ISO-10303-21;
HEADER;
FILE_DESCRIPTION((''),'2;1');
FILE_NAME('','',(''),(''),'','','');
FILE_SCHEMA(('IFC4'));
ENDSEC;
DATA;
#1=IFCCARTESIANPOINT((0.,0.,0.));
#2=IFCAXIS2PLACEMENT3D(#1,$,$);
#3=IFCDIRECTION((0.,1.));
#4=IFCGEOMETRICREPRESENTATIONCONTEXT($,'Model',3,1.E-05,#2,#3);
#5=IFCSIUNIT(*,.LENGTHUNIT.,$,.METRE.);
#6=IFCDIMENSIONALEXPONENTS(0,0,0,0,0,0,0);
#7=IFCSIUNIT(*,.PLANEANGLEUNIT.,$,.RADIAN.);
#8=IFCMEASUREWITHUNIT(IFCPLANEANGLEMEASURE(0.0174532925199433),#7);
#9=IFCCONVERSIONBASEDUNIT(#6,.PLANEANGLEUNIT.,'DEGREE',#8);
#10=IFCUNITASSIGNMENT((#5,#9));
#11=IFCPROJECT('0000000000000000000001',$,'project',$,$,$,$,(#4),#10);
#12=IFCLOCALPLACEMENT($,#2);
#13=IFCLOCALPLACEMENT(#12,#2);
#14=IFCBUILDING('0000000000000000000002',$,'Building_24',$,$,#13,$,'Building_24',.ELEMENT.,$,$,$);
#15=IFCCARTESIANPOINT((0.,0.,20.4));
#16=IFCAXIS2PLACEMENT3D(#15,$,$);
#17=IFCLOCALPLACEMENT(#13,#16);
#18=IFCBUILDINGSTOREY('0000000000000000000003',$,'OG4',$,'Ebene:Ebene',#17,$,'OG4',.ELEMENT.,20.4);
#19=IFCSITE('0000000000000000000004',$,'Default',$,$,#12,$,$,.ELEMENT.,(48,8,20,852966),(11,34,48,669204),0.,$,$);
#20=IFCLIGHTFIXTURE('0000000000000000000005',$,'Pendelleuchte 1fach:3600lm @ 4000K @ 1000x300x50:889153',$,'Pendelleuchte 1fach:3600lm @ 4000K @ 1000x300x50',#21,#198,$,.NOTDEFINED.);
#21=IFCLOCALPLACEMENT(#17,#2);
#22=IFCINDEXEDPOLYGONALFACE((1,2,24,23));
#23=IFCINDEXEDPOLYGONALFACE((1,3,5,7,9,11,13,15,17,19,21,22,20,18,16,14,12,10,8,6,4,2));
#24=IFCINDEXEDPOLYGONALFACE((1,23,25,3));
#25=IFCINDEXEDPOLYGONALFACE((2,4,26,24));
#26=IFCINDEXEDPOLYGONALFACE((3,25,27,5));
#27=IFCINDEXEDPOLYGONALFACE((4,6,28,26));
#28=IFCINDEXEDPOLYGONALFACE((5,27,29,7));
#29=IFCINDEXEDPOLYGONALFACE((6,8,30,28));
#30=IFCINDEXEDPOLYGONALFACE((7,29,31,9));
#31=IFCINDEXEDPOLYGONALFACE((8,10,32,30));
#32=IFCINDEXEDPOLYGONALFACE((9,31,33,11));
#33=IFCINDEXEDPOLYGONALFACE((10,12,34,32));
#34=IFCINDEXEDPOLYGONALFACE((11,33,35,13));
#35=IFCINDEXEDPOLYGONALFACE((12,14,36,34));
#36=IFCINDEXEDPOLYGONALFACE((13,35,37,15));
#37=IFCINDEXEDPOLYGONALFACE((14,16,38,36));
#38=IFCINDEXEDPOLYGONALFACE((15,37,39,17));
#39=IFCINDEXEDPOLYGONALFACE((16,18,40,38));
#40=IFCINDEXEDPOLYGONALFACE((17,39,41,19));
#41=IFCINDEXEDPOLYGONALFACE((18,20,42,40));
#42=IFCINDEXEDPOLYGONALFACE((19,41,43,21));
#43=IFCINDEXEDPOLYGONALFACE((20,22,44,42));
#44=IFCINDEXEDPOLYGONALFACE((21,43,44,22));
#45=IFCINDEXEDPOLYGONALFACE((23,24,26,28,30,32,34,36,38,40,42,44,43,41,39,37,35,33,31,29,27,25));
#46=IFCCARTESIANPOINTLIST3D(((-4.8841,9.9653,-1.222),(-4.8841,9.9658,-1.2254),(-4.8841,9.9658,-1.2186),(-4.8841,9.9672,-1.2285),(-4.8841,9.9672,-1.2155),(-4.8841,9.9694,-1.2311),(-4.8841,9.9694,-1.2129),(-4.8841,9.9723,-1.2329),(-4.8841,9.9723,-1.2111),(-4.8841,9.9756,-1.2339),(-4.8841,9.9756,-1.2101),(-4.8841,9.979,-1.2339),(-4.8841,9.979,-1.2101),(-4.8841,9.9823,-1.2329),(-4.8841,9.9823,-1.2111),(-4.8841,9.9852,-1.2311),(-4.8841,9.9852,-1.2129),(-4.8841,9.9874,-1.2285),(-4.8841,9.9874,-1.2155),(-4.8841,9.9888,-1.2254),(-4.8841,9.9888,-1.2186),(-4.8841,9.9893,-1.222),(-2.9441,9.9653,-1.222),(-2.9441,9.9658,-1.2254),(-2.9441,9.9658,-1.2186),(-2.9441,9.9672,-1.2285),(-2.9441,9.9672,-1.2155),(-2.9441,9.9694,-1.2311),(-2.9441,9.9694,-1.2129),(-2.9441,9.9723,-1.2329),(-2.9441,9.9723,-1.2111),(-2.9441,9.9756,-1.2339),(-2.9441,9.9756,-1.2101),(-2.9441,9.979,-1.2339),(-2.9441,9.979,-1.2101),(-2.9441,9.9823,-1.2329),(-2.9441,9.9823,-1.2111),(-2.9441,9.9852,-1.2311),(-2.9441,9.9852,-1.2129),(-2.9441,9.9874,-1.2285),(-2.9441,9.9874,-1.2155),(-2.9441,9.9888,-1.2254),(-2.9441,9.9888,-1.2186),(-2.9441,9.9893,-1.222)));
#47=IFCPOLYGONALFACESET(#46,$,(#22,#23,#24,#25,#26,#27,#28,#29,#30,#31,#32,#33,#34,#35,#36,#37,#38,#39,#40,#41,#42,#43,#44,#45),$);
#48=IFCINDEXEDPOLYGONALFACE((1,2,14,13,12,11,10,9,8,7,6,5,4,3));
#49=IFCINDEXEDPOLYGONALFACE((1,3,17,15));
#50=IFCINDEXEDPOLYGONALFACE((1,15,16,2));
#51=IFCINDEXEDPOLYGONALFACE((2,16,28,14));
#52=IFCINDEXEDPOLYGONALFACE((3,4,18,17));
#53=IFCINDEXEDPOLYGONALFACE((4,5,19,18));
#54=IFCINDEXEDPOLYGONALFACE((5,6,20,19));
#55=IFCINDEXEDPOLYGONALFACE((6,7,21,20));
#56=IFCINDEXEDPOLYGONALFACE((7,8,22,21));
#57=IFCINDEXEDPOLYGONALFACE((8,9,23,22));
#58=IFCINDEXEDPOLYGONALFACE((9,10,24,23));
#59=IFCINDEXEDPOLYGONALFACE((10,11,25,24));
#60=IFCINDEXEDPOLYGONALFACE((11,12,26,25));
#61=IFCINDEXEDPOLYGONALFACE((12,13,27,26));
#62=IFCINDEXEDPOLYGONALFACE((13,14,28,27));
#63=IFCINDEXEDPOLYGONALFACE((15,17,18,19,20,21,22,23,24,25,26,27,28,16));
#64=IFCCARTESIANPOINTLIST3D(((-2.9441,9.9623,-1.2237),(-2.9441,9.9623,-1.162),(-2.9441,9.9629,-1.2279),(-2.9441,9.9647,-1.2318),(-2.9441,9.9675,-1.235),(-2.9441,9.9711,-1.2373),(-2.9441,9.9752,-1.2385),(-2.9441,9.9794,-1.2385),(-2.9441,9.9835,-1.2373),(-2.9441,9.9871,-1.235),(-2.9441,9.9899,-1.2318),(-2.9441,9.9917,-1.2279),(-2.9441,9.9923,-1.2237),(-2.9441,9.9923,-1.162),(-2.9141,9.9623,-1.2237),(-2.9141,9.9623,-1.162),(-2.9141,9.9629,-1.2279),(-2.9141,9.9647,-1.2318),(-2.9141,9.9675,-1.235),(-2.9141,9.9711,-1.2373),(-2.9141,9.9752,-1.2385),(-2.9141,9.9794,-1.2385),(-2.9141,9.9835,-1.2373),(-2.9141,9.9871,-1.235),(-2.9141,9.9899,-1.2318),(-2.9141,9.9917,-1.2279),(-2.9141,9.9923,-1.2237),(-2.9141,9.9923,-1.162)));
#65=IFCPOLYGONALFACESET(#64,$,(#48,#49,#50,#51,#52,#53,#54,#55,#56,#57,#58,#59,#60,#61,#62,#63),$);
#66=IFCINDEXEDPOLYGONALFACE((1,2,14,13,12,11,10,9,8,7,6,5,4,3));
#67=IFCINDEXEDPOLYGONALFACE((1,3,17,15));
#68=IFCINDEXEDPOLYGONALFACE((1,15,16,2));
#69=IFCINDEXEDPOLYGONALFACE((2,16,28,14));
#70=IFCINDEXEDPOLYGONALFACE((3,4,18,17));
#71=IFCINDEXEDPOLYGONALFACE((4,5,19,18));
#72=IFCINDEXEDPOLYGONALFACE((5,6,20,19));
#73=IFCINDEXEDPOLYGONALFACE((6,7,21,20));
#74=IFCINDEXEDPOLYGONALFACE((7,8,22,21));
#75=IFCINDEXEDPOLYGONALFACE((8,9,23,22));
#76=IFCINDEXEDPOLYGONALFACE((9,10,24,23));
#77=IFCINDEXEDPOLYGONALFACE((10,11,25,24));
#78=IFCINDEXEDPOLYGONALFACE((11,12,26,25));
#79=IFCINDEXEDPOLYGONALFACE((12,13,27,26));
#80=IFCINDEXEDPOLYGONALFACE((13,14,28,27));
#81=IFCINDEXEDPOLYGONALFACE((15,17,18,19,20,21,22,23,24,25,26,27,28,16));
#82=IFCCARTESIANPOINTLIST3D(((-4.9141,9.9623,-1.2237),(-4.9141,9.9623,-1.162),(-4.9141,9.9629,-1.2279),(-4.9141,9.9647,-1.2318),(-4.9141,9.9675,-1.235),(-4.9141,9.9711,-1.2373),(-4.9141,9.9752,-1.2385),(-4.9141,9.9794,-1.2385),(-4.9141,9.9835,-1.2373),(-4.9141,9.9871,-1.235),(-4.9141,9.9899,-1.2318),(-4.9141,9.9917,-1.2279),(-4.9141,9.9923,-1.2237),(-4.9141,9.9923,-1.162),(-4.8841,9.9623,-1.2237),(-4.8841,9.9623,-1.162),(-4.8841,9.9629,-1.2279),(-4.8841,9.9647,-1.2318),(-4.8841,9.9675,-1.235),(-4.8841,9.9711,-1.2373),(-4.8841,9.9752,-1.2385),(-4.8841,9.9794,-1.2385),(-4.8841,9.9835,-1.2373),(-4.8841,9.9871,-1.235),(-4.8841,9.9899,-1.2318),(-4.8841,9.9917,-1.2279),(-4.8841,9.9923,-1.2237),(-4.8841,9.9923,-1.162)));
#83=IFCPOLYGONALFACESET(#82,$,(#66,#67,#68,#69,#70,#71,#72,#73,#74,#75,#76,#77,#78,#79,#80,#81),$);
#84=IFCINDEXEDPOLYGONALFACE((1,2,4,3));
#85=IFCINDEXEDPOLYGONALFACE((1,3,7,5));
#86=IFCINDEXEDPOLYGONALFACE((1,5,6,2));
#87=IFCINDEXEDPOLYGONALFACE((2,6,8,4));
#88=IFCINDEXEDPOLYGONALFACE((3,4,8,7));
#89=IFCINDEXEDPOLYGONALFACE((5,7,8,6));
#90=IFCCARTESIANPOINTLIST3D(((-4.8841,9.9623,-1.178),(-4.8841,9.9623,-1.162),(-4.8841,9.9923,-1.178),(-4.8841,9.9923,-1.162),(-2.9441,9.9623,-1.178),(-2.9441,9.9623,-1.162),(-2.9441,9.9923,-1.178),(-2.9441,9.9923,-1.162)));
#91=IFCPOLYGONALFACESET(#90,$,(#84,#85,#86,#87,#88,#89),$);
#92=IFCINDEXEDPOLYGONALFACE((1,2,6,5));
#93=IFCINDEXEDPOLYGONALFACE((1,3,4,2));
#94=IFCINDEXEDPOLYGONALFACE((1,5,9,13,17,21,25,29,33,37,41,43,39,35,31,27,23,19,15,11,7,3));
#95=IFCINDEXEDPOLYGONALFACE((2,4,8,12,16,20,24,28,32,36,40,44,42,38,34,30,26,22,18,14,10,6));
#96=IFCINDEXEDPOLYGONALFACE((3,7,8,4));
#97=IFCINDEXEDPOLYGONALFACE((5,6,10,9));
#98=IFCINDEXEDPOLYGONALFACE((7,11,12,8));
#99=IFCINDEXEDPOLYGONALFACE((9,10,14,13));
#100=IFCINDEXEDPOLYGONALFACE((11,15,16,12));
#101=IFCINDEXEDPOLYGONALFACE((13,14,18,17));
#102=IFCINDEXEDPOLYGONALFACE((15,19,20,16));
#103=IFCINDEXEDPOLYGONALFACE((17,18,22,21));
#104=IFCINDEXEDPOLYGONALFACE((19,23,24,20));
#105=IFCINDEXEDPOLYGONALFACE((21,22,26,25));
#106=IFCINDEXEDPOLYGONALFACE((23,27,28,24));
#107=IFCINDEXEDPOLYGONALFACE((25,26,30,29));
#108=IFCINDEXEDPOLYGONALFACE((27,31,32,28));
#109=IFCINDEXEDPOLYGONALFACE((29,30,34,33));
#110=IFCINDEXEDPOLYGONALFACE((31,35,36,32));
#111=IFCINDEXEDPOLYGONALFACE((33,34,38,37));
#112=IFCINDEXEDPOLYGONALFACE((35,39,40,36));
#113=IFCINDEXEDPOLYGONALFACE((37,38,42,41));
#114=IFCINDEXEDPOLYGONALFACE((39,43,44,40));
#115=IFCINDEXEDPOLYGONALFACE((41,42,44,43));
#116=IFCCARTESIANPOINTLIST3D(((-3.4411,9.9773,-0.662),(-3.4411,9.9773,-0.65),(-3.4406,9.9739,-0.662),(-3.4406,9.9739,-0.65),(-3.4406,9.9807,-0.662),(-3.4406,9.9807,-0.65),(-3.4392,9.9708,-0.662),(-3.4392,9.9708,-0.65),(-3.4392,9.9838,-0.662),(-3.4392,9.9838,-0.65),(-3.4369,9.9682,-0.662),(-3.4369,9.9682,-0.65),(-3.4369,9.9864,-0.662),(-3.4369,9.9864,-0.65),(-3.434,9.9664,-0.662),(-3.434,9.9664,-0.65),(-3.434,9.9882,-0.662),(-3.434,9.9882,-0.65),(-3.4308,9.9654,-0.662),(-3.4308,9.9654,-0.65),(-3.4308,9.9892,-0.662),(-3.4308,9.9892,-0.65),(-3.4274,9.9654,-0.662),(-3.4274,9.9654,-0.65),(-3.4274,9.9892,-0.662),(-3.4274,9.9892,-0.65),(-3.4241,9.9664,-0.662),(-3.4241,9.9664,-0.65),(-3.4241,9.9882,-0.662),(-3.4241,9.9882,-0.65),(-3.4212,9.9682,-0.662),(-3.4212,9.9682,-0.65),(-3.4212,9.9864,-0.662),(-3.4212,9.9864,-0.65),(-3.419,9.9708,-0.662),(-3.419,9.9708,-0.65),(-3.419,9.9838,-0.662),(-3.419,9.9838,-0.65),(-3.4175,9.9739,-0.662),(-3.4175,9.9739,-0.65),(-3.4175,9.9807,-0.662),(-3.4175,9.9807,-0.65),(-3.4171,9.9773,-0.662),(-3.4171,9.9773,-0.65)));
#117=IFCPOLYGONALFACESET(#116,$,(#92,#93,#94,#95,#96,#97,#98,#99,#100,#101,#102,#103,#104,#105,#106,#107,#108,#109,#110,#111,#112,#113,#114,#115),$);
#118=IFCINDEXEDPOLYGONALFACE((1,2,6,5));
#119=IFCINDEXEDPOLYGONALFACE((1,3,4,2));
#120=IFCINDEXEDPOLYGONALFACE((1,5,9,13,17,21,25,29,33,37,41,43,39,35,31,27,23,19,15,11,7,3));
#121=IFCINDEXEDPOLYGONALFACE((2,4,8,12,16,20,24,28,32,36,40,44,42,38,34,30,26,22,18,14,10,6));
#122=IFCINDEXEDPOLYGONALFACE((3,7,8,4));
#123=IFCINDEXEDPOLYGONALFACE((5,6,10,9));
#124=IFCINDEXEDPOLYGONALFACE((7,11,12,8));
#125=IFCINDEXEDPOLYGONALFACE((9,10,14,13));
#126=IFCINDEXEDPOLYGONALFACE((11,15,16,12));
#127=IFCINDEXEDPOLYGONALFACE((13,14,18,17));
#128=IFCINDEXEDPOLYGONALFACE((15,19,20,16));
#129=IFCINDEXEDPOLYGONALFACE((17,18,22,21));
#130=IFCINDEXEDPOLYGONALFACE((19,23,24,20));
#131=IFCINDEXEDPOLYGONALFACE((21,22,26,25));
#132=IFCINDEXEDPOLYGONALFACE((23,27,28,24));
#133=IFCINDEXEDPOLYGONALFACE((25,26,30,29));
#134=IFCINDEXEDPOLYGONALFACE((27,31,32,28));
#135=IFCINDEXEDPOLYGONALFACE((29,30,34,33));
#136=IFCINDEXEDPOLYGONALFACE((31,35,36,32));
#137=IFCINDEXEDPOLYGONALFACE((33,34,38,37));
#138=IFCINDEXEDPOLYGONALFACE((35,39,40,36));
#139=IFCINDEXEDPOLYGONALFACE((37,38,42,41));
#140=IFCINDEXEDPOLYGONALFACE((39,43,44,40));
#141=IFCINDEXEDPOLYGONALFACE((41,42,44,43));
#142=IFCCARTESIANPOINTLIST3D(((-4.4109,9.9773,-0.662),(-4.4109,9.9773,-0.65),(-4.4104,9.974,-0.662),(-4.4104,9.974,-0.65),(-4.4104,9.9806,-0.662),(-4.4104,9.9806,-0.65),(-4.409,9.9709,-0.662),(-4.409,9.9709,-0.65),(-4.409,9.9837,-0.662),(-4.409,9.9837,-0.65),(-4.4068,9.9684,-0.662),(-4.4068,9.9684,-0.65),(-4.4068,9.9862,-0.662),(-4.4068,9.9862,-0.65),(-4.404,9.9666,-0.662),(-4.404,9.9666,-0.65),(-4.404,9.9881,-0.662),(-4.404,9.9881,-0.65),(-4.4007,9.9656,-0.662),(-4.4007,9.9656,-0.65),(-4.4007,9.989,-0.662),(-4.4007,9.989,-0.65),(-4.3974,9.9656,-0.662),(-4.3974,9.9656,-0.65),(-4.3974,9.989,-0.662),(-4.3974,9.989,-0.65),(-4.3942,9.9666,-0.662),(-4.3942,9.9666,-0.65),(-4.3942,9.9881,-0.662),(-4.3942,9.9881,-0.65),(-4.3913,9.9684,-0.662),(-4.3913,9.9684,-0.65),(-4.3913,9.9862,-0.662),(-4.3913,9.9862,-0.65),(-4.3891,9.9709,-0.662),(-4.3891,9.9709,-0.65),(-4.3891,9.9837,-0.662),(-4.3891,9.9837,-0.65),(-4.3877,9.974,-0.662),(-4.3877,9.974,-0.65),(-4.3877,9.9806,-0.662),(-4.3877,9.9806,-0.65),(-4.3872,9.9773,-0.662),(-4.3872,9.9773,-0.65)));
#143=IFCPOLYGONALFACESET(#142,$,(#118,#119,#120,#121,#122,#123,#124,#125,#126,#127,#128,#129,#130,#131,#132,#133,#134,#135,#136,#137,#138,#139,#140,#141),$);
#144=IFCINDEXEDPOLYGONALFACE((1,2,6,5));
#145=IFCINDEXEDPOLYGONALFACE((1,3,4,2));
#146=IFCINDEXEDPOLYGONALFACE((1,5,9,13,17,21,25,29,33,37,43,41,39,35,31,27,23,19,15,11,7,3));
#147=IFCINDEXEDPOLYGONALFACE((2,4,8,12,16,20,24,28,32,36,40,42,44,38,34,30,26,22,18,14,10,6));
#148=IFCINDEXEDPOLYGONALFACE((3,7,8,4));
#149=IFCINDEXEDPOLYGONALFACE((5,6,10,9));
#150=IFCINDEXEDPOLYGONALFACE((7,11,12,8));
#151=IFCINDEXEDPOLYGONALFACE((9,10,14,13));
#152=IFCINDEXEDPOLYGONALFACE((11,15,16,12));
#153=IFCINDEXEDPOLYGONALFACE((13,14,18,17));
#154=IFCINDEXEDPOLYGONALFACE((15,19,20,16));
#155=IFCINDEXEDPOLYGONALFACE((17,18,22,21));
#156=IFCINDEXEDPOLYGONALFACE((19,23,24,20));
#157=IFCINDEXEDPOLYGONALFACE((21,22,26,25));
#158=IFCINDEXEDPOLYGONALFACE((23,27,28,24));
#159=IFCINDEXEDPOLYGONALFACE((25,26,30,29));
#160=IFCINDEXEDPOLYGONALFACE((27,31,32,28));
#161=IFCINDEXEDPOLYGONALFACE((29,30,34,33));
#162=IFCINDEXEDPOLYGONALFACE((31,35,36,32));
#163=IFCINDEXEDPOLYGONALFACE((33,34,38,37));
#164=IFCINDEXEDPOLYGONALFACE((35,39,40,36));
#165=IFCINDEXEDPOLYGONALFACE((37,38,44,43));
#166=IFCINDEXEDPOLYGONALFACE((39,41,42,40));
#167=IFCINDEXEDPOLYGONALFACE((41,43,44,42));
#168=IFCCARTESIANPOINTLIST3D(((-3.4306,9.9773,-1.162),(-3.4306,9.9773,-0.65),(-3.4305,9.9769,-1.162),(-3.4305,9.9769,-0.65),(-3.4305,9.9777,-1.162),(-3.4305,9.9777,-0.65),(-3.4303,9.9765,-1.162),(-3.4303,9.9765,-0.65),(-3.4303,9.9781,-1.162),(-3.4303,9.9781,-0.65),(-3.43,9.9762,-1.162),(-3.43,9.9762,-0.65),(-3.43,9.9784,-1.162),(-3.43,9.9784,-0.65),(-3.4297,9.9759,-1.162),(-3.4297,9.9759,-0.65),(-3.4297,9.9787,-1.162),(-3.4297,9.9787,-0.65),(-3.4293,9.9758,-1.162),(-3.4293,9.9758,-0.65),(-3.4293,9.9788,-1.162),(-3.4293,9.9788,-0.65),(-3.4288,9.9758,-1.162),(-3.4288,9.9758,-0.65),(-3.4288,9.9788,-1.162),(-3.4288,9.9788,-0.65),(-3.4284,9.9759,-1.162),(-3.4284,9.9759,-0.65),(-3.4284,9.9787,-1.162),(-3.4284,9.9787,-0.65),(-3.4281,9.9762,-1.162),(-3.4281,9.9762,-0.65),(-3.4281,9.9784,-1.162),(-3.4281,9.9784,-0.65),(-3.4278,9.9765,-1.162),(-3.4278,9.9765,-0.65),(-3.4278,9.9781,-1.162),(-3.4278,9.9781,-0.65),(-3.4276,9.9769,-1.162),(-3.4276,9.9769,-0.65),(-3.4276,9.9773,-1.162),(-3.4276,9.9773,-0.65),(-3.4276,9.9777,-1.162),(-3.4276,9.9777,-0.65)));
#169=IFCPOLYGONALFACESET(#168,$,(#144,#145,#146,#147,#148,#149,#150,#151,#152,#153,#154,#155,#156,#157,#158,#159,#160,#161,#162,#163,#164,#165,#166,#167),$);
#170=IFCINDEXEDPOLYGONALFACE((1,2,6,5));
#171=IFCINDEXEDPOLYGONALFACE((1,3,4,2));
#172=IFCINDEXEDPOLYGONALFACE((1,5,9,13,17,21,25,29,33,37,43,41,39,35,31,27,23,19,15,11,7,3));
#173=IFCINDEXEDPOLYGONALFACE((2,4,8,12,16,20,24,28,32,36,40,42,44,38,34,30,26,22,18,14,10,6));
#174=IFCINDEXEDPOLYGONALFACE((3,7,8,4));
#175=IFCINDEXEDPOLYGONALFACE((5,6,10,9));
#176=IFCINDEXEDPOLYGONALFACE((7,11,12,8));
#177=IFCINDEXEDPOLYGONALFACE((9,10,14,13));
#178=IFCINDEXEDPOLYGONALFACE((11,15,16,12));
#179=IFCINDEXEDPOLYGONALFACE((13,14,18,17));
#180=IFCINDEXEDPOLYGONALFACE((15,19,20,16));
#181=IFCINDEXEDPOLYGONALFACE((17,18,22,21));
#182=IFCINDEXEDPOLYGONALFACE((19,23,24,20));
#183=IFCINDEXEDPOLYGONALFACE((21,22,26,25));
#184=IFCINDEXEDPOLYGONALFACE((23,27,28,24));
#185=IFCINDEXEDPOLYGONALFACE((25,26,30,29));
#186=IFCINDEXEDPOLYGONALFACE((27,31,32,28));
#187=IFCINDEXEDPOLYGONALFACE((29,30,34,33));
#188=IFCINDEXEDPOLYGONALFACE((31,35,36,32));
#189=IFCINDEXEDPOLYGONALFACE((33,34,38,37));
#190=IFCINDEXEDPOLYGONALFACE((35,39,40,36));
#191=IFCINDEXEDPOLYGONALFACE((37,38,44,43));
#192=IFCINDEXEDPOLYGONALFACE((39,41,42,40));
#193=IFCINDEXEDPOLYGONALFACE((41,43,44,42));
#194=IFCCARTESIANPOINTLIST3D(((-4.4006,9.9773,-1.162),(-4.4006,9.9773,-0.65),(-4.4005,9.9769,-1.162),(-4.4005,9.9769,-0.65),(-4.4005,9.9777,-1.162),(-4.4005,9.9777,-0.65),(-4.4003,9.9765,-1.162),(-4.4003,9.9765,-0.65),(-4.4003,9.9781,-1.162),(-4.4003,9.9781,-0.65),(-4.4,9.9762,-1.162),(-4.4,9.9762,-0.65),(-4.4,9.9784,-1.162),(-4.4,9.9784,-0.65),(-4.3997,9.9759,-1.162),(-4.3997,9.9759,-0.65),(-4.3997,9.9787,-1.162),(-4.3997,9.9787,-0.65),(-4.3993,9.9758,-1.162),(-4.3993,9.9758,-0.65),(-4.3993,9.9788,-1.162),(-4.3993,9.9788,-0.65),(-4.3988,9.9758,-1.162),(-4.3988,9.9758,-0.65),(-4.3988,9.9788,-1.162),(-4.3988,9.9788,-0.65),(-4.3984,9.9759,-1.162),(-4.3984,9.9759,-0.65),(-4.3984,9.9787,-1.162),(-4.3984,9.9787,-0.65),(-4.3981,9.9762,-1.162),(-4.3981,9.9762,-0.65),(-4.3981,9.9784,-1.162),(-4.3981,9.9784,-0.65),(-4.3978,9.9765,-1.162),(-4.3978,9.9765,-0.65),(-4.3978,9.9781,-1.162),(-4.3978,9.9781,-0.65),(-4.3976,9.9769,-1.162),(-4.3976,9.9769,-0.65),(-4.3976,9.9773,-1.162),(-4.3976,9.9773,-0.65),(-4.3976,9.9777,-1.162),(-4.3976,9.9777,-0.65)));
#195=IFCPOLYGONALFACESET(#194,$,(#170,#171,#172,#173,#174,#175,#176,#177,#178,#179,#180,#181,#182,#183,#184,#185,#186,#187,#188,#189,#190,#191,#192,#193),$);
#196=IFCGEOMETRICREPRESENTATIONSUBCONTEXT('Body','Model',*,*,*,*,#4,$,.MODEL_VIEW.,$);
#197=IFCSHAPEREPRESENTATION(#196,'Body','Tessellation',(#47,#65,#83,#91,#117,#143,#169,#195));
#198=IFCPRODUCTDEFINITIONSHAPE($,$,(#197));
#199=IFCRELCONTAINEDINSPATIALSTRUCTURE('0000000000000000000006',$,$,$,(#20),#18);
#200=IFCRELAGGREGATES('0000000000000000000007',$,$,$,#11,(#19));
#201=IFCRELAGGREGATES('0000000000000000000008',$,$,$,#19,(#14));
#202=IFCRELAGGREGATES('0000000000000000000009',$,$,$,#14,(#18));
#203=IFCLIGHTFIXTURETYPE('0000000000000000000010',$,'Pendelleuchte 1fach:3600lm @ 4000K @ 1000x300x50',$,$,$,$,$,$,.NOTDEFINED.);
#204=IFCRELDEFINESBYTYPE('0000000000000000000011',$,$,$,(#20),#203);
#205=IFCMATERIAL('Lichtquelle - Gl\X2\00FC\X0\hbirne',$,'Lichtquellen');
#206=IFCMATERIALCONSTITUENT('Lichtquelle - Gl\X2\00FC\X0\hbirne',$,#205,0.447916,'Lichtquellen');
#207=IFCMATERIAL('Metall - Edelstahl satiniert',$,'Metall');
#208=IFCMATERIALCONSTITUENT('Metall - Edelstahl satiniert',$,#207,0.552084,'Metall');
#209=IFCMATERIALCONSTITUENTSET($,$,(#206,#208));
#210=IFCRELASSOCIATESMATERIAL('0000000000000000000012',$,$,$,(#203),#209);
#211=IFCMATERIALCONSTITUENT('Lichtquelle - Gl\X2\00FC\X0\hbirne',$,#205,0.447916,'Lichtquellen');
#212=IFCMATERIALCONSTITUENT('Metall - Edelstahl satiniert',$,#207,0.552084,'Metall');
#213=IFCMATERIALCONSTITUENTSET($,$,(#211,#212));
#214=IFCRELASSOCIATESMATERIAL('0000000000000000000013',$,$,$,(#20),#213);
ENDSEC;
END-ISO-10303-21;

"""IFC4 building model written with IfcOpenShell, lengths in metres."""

from ifc_helpers import new_model, entity, si_unit, converted_unit, direction, frame, origin, place, context, subcontext, project, spatial, line, arc, indexed_curve, outline, extrude, source, transform, mapped, material, constituent, constituent_set, type_object, type_shapes, element, save


model = new_model("IFC4")

# Units and contexts
model_context = context("Model", 3, precision=1e-05, world=origin(), true_north=direction((0.0, 1.0)))
body_context = subcontext(model_context, "Body", "Model", "MODEL_VIEW")
ifc_project = project(units=[si_unit("LENGTHUNIT", "METRE"), converted_unit("PLANEANGLEUNIT", "DEGREE", entity("IfcPlaneAngleMeasure", 0.0174532925199433), si_unit("PLANEANGLEUNIT", "RADIAN"), dimensions=[0, 0, 0, 0, 0, 0, 0])], contexts=[model_context])

# Site, building, storey
site_placement = place(None, origin())
site = spatial("IfcSite", under=ifc_project, at=site_placement, Name="Default", CompositionType="ELEMENT", RefLatitude=(48, 8, 20, 852966), RefLongitude=(11, 34, 48, 669204), RefElevation=0.0)
building_placement = place(site_placement, origin())
building = spatial("IfcBuilding", under=site, at=building_placement, Name="Building_24", LongName="Building_24", CompositionType="ELEMENT")
storey_placement = place(building_placement, frame((0.0, 0.0, 20.4)))
storey = spatial("IfcBuildingStorey", under=building, at=storey_placement, Name="OG4", ObjectType="Ebene:Ebene", LongName="OG4", CompositionType="ELEMENT", Elevation=20.4)

# Light fixture
ifc_material_1 = material(Name="Lichtquelle - Glühbirne", Category="Lichtquellen")
ifc_material_2 = material(Name="Metall - Edelstahl satiniert", Category="Metall")
ifc_constituent_1 = constituent(ifc_material_1, Name="Lichtquelle - Glühbirne", Category="Lichtquellen", fraction=0.447916)
ifc_constituent_2 = constituent(ifc_material_2, Name="Metall - Edelstahl satiniert", Category="Metall", fraction=0.552084)
ifc_constituent_set_1 = constituent_set(constituents=[ifc_constituent_1, ifc_constituent_2])
light_fixture_type = type_object("IfcLightFixtureType", Name="Pendelleuchte 1fach:3600lm @ 4000K @ 1000x300x50", PredefinedType="NOTDEFINED", material=ifc_constituent_set_1)
shared_shape_1 = source(origin(), body_context, "Body", "SweptSolid", [
    extrude(outline(indexed_curve([(-0.012, 0.0), (0.0, -0.012), (0.012, 0.0), (0.0, 0.012)], segments=[arc(1, 2, 3), arc(3, 4, 1)], self_intersect=False)), frame((-0.97, 0.0, -0.572), z_axis=(1.0, 0.0, 0.0), x_axis=(0.0, 1.0, 0.0)), (0.0, 0.0, 1.0), 1.94),
    extrude(outline(indexed_curve([(-0.0308, -0.015), (0.0308, -0.015), (0.0308, 0.015), (-0.0308, 0.015), (-0.0458, 0.0)], segments=[line(1, 2, 3, 4), arc(4, 5, 1)], self_intersect=False)), frame((0.97, 0.0, -0.5428), z_axis=(1.0, 0.0, 0.0), x_axis=(0.0, 0.0, 1.0)), (0.0, 0.0, 1.0), 0.03),
    extrude(outline(indexed_curve([(-0.0308, -0.015), (0.0308, -0.015), (0.0308, 0.015), (-0.0308, 0.015), (-0.0458, 0.0)], segments=[line(1, 2, 3, 4), arc(4, 5, 1)], self_intersect=False)), frame((-1.0, 0.0, -0.5428), z_axis=(1.0, 0.0, 0.0), x_axis=(0.0, 0.0, 1.0)), (0.0, 0.0, 1.0), 0.03),
    extrude(outline(indexed_curve([(-0.97, -0.015), (0.97, -0.015), (0.97, 0.015), (-0.97, 0.015), (-0.97, -0.015)], self_intersect=False)), frame((0.0, 0.0, -0.528), z_axis=(0.0, 0.0, 1.0), x_axis=(-1.0, 0.0, 0.0)), (0.0, 0.0, 1.0), 0.016),
    extrude(outline(indexed_curve([(-0.012, 0.0), (0.0, -0.012), (0.012, 0.0), (0.0, 0.012)], segments=[arc(1, 2, 3), arc(3, 4, 1)], self_intersect=False)), frame((0.485, 0.0, -0.012)), (0.0, 0.0, 1.0), 0.012),
    extrude(outline(indexed_curve([(-0.0118, 0.0), (0.0, -0.0118), (0.0118, 0.0), (0.0, 0.0118)], segments=[arc(1, 2, 3), arc(3, 4, 1)], self_intersect=False)), frame((-0.485, 0.0, -0.012)), (0.0, 0.0, 1.0), 0.012),
    extrude(outline(indexed_curve([(-0.0015, 0.0), (0.0, -0.0015), (0.0015, 0.0), (0.0, 0.0015)], segments=[arc(1, 2, 3), arc(3, 4, 1)], self_intersect=False)), frame((0.485, 0.0, -0.512)), (0.0, 0.0, 1.0), 0.512),
    extrude(outline(indexed_curve([(-0.0015, 0.0), (0.0, -0.0015), (0.0015, 0.0), (0.0, 0.0015)], segments=[arc(1, 2, 3), arc(3, 4, 1)], self_intersect=False)), frame((-0.485, 0.0, -0.512)), (0.0, 0.0, 1.0), 0.512),
])
type_shapes(light_fixture_type, [shared_shape_1])
ifc_constituent_3 = constituent(ifc_material_1, Name="Lichtquelle - Glühbirne", Category="Lichtquellen", fraction=0.447916)
ifc_constituent_4 = constituent(ifc_material_2, Name="Metall - Edelstahl satiniert", Category="Metall", fraction=0.552084)
ifc_constituent_set_2 = constituent_set(constituents=[ifc_constituent_3, ifc_constituent_4])
light_fixture_1_placement = place(storey_placement, frame((-3.9141, 9.9773, -0.65)))
element("IfcLightFixture", 1, at=light_fixture_1_placement, inside=storey, type_object=light_fixture_type, material=ifc_constituent_set_2, Name="Pendelleuchte 1fach:3600lm @ 4000K @ 1000x300x50:889153", ObjectType="Pendelleuchte 1fach:3600lm @ 4000K @ 1000x300x50", PredefinedType="NOTDEFINED", context=body_context, shape_type="MappedRepresentation", body=[
    mapped(shared_shape_1, transform((0.0, 0.0, 0.0), scale=1.0)),
])

save(model, "model.ifc")
